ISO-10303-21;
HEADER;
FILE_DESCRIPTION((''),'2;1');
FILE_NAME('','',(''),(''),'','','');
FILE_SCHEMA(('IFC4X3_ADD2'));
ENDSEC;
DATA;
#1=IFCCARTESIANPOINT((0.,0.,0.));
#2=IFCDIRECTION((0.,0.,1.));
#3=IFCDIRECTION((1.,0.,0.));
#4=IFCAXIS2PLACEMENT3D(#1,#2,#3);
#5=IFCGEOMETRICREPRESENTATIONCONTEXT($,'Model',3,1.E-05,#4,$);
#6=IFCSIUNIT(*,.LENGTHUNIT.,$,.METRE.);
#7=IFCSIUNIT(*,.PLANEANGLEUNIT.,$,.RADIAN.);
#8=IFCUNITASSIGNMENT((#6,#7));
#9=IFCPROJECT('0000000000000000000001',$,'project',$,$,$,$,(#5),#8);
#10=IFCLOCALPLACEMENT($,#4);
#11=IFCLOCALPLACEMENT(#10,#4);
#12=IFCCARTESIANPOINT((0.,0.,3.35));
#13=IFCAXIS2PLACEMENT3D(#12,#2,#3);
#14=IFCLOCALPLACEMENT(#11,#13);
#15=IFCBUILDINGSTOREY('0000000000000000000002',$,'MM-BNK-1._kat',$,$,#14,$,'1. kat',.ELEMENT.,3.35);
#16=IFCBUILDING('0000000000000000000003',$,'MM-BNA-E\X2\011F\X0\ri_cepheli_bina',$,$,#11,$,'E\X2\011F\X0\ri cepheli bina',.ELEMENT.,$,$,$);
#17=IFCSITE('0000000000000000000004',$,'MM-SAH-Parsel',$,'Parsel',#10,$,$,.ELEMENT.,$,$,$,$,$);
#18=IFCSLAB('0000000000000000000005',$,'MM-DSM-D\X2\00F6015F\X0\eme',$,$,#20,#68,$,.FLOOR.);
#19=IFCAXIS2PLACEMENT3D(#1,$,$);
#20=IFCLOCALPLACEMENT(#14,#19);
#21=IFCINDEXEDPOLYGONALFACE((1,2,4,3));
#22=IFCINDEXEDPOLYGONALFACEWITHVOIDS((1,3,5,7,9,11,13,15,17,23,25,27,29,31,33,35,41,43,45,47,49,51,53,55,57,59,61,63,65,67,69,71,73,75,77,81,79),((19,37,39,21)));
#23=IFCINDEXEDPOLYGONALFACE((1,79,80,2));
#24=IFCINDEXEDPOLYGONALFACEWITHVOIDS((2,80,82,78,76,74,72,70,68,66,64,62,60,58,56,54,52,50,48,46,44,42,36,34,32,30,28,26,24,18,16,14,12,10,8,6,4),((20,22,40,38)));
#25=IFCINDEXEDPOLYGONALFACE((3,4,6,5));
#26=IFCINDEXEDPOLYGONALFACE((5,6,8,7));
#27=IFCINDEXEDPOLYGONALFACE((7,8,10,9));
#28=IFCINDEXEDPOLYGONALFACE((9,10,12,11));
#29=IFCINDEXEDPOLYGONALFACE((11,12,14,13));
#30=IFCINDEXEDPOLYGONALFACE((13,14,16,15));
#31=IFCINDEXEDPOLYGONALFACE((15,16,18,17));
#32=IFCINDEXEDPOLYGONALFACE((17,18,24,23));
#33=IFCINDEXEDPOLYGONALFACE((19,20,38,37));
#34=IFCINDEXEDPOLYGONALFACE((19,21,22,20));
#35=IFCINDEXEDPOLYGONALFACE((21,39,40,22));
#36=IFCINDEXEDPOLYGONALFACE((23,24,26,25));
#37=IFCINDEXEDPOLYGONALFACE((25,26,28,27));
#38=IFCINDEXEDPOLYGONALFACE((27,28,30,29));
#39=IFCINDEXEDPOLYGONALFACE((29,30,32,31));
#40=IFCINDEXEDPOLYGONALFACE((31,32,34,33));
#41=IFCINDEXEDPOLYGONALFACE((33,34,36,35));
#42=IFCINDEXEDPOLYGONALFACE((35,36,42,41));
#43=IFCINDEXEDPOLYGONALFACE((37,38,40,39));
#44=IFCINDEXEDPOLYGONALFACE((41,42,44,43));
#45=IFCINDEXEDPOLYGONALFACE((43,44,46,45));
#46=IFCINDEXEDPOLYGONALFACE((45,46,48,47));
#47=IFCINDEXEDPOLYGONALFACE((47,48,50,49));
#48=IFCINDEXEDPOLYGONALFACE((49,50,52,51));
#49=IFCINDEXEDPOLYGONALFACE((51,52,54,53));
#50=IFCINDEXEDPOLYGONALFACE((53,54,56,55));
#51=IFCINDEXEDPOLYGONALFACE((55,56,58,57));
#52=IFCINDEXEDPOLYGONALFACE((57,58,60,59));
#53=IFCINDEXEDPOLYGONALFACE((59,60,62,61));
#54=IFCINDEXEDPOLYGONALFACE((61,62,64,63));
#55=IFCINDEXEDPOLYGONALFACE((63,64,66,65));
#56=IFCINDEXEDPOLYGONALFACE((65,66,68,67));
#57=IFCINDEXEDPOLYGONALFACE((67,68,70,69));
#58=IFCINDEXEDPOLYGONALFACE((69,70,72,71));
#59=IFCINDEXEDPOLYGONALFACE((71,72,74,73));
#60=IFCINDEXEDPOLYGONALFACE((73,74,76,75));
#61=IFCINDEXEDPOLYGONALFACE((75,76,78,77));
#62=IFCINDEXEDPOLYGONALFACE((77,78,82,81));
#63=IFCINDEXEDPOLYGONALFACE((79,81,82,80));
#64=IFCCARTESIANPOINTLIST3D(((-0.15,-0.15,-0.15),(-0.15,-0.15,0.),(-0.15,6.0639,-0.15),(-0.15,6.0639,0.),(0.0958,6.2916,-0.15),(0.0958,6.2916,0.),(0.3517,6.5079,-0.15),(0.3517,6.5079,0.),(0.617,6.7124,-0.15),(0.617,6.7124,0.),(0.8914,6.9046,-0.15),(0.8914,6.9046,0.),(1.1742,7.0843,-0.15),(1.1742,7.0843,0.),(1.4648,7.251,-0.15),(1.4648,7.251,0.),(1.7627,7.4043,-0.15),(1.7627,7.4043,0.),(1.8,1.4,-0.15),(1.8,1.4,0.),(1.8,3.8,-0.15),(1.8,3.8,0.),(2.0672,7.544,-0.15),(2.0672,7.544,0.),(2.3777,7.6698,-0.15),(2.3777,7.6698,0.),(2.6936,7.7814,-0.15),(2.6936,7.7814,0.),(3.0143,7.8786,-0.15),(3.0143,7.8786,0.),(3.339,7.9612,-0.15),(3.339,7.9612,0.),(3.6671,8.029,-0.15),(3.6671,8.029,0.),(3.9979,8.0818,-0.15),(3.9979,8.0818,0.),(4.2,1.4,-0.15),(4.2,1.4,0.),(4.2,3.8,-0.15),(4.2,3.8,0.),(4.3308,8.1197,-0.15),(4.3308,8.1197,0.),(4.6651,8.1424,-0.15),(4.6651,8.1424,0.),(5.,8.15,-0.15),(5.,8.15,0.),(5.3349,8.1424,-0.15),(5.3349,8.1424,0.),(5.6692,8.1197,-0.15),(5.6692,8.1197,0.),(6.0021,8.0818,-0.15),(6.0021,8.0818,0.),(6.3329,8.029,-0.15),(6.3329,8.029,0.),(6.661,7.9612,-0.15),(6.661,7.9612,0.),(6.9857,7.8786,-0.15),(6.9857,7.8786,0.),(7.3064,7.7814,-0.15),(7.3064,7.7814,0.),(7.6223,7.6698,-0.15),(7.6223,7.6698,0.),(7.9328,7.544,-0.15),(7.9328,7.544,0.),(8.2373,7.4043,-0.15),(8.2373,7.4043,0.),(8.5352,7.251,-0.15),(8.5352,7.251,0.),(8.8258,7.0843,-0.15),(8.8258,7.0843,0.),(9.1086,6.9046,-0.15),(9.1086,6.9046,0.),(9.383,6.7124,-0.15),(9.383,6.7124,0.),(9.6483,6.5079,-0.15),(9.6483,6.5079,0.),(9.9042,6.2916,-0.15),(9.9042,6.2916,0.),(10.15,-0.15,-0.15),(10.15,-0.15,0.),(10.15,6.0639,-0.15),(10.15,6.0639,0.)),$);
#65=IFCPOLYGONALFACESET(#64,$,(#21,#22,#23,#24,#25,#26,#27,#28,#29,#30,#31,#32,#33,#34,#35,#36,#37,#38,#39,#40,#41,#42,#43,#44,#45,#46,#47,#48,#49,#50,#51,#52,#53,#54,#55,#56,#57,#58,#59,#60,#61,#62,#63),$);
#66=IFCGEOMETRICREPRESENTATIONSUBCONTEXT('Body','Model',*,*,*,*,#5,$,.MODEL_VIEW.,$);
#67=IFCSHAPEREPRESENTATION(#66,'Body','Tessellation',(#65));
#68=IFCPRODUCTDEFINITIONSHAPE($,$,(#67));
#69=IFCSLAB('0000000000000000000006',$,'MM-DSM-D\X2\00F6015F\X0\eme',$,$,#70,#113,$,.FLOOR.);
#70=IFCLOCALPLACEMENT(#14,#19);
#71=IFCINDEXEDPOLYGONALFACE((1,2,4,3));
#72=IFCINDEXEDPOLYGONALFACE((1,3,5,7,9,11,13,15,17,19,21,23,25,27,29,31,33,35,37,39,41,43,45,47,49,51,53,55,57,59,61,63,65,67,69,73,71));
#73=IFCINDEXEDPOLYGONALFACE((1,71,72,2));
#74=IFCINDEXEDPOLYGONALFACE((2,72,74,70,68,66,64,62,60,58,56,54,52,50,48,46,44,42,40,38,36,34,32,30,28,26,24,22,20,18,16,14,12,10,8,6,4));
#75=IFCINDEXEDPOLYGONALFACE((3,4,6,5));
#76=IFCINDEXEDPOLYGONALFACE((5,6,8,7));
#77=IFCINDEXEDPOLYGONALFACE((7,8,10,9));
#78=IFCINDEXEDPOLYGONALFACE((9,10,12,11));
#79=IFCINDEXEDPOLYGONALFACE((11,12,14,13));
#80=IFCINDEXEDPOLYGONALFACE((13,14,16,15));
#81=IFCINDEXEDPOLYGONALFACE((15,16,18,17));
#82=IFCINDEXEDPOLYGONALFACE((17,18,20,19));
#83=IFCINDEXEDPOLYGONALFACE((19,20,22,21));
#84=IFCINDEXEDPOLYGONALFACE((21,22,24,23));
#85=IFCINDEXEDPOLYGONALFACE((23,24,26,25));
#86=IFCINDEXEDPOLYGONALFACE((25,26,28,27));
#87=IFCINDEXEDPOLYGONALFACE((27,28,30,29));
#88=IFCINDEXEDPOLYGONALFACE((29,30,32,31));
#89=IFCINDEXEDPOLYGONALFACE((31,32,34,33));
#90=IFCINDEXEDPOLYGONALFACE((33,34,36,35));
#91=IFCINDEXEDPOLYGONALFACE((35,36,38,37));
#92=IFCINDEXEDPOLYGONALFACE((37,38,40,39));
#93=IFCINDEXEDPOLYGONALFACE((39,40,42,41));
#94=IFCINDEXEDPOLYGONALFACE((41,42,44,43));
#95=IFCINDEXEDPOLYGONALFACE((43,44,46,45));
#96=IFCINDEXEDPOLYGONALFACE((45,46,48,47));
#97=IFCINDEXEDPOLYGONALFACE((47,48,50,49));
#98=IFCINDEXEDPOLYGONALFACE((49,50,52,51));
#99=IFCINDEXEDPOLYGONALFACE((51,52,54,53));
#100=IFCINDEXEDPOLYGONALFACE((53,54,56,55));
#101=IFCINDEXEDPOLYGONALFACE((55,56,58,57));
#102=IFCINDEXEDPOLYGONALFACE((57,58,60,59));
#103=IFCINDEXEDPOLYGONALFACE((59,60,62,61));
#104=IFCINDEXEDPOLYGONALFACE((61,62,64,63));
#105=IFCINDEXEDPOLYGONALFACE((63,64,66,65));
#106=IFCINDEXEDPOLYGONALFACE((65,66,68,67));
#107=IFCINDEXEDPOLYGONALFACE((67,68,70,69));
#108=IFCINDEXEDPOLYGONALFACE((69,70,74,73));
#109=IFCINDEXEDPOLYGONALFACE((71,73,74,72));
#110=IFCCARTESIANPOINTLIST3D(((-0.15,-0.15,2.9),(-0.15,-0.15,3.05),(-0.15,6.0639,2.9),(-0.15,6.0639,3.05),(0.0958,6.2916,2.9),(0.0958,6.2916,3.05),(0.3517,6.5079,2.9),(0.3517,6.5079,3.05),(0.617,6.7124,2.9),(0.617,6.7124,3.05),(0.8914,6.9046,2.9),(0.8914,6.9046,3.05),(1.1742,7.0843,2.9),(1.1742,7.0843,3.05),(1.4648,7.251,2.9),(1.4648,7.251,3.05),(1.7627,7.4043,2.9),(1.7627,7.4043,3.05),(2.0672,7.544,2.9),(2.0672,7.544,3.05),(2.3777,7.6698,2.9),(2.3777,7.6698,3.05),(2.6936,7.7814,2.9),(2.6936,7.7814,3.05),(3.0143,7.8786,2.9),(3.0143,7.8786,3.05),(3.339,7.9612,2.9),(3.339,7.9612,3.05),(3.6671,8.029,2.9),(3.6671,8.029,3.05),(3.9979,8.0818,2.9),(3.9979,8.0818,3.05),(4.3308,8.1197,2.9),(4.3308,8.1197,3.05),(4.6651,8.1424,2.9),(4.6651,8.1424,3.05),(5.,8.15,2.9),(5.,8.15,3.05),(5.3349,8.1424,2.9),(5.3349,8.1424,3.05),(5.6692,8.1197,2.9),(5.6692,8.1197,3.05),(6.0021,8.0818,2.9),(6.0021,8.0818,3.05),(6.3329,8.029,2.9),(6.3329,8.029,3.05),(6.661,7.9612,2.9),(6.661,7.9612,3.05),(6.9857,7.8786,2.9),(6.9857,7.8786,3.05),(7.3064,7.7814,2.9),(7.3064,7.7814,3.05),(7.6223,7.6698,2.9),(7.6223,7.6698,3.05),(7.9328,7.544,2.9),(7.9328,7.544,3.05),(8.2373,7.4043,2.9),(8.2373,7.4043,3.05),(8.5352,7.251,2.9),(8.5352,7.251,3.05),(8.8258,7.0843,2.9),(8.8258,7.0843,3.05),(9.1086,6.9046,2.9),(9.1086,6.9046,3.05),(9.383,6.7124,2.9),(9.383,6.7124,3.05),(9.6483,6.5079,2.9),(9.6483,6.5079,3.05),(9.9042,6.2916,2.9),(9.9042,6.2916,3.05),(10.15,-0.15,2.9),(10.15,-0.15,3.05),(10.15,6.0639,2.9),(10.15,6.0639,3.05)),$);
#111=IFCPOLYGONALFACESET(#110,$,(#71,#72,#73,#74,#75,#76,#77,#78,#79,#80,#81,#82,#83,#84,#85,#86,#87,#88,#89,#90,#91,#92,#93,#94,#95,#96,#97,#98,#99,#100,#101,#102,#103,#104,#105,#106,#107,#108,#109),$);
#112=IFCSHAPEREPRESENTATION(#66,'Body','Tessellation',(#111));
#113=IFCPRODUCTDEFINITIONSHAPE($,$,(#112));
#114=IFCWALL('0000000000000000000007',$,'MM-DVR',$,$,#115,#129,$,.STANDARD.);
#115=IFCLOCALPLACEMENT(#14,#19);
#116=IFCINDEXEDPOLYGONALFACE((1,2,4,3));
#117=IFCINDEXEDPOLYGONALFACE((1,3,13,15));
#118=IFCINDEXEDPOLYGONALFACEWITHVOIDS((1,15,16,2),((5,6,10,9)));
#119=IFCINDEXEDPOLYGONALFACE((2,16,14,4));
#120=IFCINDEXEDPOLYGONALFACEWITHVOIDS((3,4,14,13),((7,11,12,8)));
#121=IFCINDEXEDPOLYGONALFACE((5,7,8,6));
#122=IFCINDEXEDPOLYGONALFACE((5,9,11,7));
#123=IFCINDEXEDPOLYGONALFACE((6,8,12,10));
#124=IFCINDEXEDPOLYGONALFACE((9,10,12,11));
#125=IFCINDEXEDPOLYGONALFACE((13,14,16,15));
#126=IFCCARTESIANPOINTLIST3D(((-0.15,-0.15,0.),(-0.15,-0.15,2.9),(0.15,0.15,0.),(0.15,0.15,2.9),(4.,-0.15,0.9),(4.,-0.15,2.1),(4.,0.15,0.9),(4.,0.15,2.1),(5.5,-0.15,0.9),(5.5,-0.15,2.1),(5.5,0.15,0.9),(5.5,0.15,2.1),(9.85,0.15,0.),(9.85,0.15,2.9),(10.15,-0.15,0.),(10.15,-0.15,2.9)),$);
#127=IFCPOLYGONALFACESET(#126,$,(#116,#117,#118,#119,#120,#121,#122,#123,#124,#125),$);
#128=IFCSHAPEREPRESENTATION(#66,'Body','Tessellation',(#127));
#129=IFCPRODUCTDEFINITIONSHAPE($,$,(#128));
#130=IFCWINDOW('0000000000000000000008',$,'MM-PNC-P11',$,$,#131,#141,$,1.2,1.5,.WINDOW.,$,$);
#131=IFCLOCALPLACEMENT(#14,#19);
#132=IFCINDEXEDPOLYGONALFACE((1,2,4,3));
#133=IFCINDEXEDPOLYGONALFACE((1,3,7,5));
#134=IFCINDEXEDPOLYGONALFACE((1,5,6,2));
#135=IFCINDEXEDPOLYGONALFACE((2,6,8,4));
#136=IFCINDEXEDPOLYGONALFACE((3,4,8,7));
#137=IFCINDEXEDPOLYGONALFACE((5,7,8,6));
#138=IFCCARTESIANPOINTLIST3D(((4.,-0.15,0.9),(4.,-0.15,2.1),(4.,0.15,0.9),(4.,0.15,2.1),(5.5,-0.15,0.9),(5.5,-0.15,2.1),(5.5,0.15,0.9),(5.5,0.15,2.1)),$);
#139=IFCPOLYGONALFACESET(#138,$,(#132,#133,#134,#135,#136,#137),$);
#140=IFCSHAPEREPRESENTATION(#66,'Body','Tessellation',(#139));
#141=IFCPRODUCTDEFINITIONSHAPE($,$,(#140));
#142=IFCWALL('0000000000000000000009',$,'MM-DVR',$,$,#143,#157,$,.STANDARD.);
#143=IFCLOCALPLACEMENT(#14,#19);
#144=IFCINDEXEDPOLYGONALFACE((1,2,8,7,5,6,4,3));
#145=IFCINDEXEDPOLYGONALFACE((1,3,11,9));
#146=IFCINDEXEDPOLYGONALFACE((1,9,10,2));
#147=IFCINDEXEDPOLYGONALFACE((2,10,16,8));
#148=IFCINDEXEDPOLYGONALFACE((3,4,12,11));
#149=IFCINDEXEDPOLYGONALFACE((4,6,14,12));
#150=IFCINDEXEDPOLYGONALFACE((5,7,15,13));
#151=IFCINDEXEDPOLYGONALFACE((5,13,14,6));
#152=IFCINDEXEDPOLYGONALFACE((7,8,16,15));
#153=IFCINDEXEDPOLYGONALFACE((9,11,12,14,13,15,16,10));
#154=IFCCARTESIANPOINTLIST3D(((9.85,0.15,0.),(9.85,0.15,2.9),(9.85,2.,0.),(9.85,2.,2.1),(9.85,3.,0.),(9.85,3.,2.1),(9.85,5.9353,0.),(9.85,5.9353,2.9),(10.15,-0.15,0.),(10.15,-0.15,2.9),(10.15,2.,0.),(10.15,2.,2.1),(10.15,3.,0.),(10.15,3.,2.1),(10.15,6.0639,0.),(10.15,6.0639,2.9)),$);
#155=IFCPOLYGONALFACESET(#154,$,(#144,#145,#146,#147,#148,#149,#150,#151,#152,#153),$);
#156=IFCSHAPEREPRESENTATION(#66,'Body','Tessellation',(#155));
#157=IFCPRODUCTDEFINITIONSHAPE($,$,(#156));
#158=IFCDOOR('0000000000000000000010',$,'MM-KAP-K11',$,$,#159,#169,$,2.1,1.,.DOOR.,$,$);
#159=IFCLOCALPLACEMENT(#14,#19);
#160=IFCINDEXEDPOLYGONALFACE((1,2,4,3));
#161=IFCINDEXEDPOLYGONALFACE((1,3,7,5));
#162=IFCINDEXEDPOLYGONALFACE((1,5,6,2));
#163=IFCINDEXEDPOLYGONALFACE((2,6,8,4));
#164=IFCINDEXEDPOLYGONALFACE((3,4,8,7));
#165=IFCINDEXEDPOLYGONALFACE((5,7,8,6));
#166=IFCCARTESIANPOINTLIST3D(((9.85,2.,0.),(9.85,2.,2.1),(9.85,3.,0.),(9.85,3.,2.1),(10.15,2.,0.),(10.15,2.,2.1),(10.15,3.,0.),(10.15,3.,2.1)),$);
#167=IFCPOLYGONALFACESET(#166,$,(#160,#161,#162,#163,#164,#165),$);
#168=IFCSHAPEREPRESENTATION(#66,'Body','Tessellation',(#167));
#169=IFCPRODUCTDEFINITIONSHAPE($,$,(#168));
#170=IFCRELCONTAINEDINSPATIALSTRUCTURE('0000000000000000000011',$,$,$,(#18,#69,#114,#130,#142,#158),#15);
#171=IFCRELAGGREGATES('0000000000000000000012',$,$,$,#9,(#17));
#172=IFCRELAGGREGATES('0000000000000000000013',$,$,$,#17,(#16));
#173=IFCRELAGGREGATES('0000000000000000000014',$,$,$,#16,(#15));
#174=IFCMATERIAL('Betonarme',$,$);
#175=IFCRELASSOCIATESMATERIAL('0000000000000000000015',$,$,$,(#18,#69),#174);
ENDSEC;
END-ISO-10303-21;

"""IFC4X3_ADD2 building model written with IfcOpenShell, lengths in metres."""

from ifc_helpers import new_model, si_unit, frame, origin, origin_with_axes, place, context, subcontext, project, spatial, polyline, line, arc, indexed_curve, outline, extrude, material, element, fill, save


model = new_model("IFC4X3_ADD2")

# Units and contexts
model_context = context("Model", 3, precision=1e-05, world=origin_with_axes())
body_context = subcontext(model_context, "Body", "Model", "MODEL_VIEW")
ifc_project = project(units=[si_unit("LENGTHUNIT", "METRE"), si_unit("PLANEANGLEUNIT", "RADIAN")], contexts=[model_context])

# Site, building, storey
site_placement = place(None, origin_with_axes())
site = spatial("IfcSite", under=ifc_project, at=site_placement, Name="MM-SAH-Parsel", ObjectType="Parsel", CompositionType="ELEMENT")
building_placement = place(site_placement, origin_with_axes())
building = spatial("IfcBuilding", under=site, at=building_placement, Name="MM-BNA-Eğri_cepheli_bina", LongName="Eğri cepheli bina", CompositionType="ELEMENT")
storey_placement = place(building_placement, frame((0.0, 0.0, 3.35), z_axis=(0.0, 0.0, 1.0), x_axis=(1.0, 0.0, 0.0)))
storey = spatial("IfcBuildingStorey", under=building, at=storey_placement, Name="MM-BNK-1._kat", LongName="1. kat", CompositionType="ELEMENT", Elevation=3.35)

# Slab, opening
ifc_material = material(Name="Betonarme")
slab_1_placement = place(storey_placement, origin_with_axes())
slab_1 = element("IfcSlab", 1, at=slab_1_placement, inside=storey, material=ifc_material, Name="MM-DSM-Döşeme", PredefinedType="FLOOR", context=body_context, shape_type="SweptSolid", body=[
    extrude(outline(indexed_curve([(-0.15, -0.15), (10.15, -0.15), (10.15, 6.0639), (5.0, 8.15), (-0.15, 6.0639)], segments=[line(1, 2, 3), arc(3, 4, 5), line(5, 1)], self_intersect=False)), frame((0.0, 0.0, -0.15)), (0.0, 0.0, 1.0), 0.15),
])
opening_1_placement = place(storey_placement, origin_with_axes())
element("IfcOpeningElement", 2, at=opening_1_placement, cuts=slab_1, PredefinedType="OPENING", context=body_context, shape_type="SweptSolid", body=[
    extrude(outline(polyline([(1.8, 1.4), (4.2, 1.4), (4.2, 3.8), (1.8, 3.8), (1.8, 1.4)])), frame((0.0, 0.0, -0.15)), (0.0, 0.0, 1.0), 0.15),
])

# Slab
slab_2_placement = place(storey_placement, origin_with_axes())
element("IfcSlab", 3, at=slab_2_placement, inside=storey, material=ifc_material, Name="MM-DSM-Döşeme", PredefinedType="FLOOR", context=body_context, shape_type="SweptSolid", body=[
    extrude(outline(indexed_curve([(-0.15, -0.15), (10.15, -0.15), (10.15, 6.0639), (5.0, 8.15), (-0.15, 6.0639)], segments=[line(1, 2, 3), arc(3, 4, 5), line(5, 1)], self_intersect=False)), frame((0.0, 0.0, 2.9)), (0.0, 0.0, 1.0), 0.15),
])

# Wall, opening, window
wall_1_placement = place(storey_placement, origin_with_axes())
wall_1 = element("IfcWall", 4, at=wall_1_placement, inside=storey, Name="MM-DVR", PredefinedType="STANDARD", context=body_context, shape_type="SweptSolid", body=[
    extrude(outline(polyline([(0.15, 0.15), (9.85, 0.15), (10.15, -0.15), (-0.15, -0.15), (0.15, 0.15)])), origin(), (0.0, 0.0, 1.0), 2.9),
])
opening_2_placement = place(storey_placement, origin_with_axes())
opening_2 = element("IfcOpeningElement", 5, at=opening_2_placement, cuts=wall_1, PredefinedType="OPENING", context=body_context, shape_type="SweptSolid", body=[
    extrude(outline(polyline([(4.0, 0.15), (5.5, 0.15), (5.5, -0.15), (4.0, -0.15), (4.0, 0.15)])), frame((0.0, 0.0, 0.9)), (0.0, 0.0, 1.0), 1.2),
])
window_1_placement = place(storey_placement, origin_with_axes())
window_1 = element("IfcWindow", 6, at=window_1_placement, inside=storey, Name="MM-PNC-P11", OverallHeight=1.2, OverallWidth=1.5, PredefinedType="WINDOW", context=body_context, shape_type="SweptSolid", body=[
    extrude(outline(polyline([(4.0, 0.15), (5.5, 0.15), (5.5, -0.15), (4.0, -0.15), (4.0, 0.15)])), frame((0.0, 0.0, 0.9)), (0.0, 0.0, 1.0), 1.2),
])
fill(opening_2, window_1)

# Wall, opening, door
wall_2_placement = place(storey_placement, origin_with_axes())
wall_2 = element("IfcWall", 7, at=wall_2_placement, inside=storey, Name="MM-DVR", PredefinedType="STANDARD", context=body_context, shape_type="SweptSolid", body=[
    extrude(outline(polyline([(9.85, 0.15), (9.85, 5.9353), (10.15, 6.0639), (10.15, -0.15), (9.85, 0.15)])), origin(), (0.0, 0.0, 1.0), 2.9),
])
opening_3_placement = place(storey_placement, origin_with_axes())
opening_3 = element("IfcOpeningElement", 8, at=opening_3_placement, cuts=wall_2, PredefinedType="OPENING", context=body_context, shape_type="SweptSolid", body=[
    extrude(outline(polyline([(9.85, 2.0), (9.85, 3.0), (10.15, 3.0), (10.15, 2.0), (9.85, 2.0)])), origin(), (0.0, 0.0, 1.0), 2.1),
])
door_placement = place(storey_placement, origin_with_axes())
door = element("IfcDoor", 9, at=door_placement, inside=storey, Name="MM-KAP-K11", OverallHeight=2.1, OverallWidth=1.0, PredefinedType="DOOR", context=body_context, shape_type="SweptSolid", body=[
    extrude(outline(polyline([(9.85, 2.0), (9.85, 3.0), (10.15, 3.0), (10.15, 2.0), (9.85, 2.0)])), origin(), (0.0, 0.0, 1.0), 2.1),
])
fill(opening_3, door)

save(model, "model.ifc")
